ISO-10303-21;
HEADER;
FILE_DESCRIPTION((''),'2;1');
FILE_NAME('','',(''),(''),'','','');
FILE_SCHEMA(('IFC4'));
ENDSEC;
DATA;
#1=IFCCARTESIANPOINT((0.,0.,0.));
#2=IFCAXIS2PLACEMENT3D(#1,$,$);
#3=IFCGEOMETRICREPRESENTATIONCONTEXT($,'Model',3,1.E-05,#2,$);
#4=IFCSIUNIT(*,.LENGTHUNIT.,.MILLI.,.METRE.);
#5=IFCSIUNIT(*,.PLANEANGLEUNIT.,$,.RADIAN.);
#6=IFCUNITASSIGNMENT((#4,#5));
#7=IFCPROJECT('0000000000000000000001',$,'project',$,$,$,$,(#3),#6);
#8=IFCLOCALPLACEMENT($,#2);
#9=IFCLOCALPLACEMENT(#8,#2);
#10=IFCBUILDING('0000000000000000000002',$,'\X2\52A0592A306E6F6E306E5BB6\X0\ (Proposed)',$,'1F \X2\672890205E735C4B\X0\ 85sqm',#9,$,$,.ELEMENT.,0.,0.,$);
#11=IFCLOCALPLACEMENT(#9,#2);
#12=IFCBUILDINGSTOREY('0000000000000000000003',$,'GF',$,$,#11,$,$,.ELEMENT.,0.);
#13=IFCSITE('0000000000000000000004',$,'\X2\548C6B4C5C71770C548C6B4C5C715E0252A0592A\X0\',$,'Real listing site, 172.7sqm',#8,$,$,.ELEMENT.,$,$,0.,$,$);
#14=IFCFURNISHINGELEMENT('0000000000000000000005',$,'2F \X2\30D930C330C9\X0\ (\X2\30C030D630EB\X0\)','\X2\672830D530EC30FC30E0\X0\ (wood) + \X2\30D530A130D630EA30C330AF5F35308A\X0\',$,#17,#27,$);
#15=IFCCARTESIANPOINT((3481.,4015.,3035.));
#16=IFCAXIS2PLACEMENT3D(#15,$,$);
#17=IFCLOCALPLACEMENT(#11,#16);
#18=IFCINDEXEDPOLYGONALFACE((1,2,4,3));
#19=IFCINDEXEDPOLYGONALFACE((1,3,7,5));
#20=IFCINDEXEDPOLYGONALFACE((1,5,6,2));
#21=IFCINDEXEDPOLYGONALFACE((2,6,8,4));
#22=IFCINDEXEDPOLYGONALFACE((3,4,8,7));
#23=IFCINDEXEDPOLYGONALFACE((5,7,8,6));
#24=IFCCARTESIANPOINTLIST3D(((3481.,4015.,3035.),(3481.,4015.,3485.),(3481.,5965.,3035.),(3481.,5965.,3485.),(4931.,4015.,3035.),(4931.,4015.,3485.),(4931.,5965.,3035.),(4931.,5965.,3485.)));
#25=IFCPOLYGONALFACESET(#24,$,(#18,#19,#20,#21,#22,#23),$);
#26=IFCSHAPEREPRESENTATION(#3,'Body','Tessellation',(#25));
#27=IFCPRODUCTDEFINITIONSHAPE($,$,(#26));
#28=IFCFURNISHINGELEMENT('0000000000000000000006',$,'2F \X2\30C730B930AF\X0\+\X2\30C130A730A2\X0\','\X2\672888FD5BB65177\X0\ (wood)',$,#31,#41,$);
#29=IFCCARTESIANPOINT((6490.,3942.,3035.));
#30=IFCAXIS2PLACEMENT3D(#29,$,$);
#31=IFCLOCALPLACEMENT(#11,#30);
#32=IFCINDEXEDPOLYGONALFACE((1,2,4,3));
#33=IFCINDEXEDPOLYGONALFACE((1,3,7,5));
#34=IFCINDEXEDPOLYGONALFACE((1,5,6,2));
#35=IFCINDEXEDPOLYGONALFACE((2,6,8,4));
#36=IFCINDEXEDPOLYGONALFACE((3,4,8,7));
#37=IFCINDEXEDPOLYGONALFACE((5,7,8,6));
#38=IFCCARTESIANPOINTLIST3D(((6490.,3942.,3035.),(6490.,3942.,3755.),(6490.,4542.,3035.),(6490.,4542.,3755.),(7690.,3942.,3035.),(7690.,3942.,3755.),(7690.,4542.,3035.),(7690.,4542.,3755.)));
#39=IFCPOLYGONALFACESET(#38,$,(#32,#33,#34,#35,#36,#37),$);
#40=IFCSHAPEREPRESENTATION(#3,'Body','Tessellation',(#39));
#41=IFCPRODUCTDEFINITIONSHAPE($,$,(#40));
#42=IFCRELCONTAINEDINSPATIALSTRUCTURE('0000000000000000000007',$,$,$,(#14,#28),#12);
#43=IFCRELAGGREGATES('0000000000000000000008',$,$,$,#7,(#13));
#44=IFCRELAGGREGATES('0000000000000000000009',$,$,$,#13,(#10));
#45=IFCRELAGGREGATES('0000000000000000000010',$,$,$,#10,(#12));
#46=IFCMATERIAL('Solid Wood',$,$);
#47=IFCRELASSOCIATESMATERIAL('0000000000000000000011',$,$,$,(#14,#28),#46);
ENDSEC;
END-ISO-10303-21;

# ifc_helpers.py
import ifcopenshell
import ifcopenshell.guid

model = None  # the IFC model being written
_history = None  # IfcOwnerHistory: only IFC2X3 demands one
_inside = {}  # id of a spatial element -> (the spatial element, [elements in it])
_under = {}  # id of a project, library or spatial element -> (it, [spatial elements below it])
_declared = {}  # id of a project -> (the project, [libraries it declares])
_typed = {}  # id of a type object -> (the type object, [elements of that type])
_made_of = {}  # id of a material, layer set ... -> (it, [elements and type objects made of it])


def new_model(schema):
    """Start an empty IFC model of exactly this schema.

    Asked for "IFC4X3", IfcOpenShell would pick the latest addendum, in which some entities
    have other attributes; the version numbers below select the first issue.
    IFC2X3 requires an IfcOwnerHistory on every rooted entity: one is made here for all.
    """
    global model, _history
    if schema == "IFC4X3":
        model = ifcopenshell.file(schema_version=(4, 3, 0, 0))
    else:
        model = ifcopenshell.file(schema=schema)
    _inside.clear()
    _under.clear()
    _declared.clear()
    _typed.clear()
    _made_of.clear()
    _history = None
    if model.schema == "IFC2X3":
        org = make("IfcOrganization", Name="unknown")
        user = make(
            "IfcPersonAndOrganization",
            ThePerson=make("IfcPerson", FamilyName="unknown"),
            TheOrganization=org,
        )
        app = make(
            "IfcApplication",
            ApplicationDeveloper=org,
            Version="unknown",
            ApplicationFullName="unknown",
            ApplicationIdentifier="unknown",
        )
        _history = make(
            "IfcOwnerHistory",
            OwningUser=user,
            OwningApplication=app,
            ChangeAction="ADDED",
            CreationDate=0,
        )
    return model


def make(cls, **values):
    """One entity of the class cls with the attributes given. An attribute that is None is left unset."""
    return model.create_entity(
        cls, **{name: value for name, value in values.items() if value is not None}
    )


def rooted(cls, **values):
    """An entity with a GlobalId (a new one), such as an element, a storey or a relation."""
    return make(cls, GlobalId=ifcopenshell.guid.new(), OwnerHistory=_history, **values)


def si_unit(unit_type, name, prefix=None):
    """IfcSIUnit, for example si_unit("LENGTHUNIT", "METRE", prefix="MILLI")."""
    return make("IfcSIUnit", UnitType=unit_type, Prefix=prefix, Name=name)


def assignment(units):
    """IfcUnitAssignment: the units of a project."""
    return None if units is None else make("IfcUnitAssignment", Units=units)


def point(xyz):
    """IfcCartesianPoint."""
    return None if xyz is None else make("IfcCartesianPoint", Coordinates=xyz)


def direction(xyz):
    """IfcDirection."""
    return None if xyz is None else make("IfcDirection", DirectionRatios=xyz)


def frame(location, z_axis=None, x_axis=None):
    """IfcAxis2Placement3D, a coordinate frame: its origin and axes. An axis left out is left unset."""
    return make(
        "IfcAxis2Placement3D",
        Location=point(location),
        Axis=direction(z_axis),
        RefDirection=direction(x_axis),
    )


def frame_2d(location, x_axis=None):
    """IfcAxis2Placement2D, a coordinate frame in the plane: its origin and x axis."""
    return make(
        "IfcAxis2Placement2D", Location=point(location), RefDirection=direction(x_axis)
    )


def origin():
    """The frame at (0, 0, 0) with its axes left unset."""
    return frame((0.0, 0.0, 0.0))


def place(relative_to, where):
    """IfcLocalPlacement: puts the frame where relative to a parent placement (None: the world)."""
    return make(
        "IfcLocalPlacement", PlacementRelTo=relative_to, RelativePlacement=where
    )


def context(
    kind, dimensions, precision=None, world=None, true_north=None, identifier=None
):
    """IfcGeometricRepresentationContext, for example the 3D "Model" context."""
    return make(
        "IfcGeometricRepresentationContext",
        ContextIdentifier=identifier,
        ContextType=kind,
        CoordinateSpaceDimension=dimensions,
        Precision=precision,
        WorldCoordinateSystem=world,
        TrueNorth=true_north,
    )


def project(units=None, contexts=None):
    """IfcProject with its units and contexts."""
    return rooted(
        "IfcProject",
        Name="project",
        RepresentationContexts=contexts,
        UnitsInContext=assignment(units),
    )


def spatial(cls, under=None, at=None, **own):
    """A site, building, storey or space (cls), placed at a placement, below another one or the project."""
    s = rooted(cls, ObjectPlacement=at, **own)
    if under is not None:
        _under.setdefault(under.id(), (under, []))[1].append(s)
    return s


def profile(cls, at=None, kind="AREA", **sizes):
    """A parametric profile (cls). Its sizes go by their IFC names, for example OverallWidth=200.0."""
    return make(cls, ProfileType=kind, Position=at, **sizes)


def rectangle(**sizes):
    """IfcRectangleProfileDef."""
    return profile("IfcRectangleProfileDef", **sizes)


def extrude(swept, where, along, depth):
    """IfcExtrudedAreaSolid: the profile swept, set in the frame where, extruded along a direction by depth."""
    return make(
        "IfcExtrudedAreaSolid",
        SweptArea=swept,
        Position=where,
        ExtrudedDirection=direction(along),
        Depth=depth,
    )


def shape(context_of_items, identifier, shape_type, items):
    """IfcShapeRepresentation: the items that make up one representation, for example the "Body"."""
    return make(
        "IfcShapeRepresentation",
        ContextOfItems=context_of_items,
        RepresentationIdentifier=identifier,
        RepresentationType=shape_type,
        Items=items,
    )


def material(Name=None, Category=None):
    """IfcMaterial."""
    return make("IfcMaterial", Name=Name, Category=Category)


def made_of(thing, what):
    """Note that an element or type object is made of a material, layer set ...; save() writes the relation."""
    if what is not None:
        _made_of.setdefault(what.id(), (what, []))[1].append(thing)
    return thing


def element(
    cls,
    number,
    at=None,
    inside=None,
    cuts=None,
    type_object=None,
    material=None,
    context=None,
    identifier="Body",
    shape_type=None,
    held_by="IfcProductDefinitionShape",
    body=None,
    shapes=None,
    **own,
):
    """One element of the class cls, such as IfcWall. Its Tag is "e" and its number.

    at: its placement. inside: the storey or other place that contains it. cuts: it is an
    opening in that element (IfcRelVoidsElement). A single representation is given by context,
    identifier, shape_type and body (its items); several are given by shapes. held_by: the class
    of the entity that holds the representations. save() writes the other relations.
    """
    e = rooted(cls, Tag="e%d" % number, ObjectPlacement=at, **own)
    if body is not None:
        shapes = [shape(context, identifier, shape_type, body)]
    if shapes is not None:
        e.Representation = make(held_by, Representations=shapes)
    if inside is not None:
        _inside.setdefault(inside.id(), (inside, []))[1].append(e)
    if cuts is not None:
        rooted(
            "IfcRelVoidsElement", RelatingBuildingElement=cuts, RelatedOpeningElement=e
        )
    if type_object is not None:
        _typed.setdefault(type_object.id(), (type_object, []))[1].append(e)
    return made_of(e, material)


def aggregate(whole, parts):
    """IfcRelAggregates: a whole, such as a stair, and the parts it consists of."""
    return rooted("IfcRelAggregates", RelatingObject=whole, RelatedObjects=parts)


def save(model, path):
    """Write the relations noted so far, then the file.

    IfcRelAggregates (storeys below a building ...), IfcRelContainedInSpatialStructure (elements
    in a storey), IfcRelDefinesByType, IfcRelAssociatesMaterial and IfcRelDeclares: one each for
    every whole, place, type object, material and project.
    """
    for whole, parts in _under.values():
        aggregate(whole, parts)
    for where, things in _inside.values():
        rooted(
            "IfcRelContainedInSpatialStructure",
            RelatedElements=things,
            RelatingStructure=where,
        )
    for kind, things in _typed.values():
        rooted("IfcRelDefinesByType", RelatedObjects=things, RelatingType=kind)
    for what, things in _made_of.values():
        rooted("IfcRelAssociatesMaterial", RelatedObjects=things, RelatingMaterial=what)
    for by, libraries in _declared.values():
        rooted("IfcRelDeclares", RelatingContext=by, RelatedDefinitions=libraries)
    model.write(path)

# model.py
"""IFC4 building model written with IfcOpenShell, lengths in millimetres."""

from ifc_helpers import new_model, si_unit, frame, frame_2d, origin, place, context, project, spatial, rectangle, extrude, material, element, save


model = new_model("IFC4")

# Units and contexts
model_context = context("Model", 3, precision=1e-05, world=origin())
ifc_project = project(units=[si_unit("LENGTHUNIT", "METRE", prefix="MILLI"), si_unit("PLANEANGLEUNIT", "RADIAN")], contexts=[model_context])

# Site, building, storey
site_placement = place(None, origin())
site = spatial("IfcSite", under=ifc_project, at=site_placement, Name="和歌山県和歌山市加太", ObjectType="Real listing site, 172.7sqm", CompositionType="ELEMENT", RefElevation=0.0)
building_placement = place(site_placement, origin())
building = spatial("IfcBuilding", under=site, at=building_placement, Name="加太の潮の家 (Proposed)", ObjectType="1F 木造平屋 85sqm", CompositionType="ELEMENT", ElevationOfRefHeight=0.0, ElevationOfTerrain=0.0)
storey_placement = place(building_placement, origin())
storey = spatial("IfcBuildingStorey", under=building, at=storey_placement, Name="GF", CompositionType="ELEMENT", Elevation=0.0)

# Shared definitions
ifc_material_1 = material(Name="Solid Wood")

# Furnishing elements
furnishing_1_placement = place(storey_placement, frame((3481.0, 4015.0, 3035.0)))
element("IfcFurnishingElement", 1, at=furnishing_1_placement, inside=storey, material=ifc_material_1, Name="2F ベッド (ダブル)", Description="木フレーム (wood) + ファブリック張り", context=model_context, shape_type="SweptSolid", body=[
    extrude(rectangle(XDim=1450.0, YDim=1950.0, at=frame_2d((725.0, 975.0))), frame((3481.0, 4015.0, 3035.0)), (0.0, 0.0, 1.0), 450.0),
])
furnishing_2_placement = place(storey_placement, frame((6490.0, 3942.0, 3035.0)))
element("IfcFurnishingElement", 2, at=furnishing_2_placement, inside=storey, material=ifc_material_1, Name="2F デスク+チェア", Description="木製家具 (wood)", context=model_context, shape_type="SweptSolid", body=[
    extrude(rectangle(XDim=1200.0, YDim=600.0, at=frame_2d((600.0, 300.0))), frame((6490.0, 3942.0, 3035.0)), (0.0, 0.0, 1.0), 720.0),
])

save(model, "model.ifc")
